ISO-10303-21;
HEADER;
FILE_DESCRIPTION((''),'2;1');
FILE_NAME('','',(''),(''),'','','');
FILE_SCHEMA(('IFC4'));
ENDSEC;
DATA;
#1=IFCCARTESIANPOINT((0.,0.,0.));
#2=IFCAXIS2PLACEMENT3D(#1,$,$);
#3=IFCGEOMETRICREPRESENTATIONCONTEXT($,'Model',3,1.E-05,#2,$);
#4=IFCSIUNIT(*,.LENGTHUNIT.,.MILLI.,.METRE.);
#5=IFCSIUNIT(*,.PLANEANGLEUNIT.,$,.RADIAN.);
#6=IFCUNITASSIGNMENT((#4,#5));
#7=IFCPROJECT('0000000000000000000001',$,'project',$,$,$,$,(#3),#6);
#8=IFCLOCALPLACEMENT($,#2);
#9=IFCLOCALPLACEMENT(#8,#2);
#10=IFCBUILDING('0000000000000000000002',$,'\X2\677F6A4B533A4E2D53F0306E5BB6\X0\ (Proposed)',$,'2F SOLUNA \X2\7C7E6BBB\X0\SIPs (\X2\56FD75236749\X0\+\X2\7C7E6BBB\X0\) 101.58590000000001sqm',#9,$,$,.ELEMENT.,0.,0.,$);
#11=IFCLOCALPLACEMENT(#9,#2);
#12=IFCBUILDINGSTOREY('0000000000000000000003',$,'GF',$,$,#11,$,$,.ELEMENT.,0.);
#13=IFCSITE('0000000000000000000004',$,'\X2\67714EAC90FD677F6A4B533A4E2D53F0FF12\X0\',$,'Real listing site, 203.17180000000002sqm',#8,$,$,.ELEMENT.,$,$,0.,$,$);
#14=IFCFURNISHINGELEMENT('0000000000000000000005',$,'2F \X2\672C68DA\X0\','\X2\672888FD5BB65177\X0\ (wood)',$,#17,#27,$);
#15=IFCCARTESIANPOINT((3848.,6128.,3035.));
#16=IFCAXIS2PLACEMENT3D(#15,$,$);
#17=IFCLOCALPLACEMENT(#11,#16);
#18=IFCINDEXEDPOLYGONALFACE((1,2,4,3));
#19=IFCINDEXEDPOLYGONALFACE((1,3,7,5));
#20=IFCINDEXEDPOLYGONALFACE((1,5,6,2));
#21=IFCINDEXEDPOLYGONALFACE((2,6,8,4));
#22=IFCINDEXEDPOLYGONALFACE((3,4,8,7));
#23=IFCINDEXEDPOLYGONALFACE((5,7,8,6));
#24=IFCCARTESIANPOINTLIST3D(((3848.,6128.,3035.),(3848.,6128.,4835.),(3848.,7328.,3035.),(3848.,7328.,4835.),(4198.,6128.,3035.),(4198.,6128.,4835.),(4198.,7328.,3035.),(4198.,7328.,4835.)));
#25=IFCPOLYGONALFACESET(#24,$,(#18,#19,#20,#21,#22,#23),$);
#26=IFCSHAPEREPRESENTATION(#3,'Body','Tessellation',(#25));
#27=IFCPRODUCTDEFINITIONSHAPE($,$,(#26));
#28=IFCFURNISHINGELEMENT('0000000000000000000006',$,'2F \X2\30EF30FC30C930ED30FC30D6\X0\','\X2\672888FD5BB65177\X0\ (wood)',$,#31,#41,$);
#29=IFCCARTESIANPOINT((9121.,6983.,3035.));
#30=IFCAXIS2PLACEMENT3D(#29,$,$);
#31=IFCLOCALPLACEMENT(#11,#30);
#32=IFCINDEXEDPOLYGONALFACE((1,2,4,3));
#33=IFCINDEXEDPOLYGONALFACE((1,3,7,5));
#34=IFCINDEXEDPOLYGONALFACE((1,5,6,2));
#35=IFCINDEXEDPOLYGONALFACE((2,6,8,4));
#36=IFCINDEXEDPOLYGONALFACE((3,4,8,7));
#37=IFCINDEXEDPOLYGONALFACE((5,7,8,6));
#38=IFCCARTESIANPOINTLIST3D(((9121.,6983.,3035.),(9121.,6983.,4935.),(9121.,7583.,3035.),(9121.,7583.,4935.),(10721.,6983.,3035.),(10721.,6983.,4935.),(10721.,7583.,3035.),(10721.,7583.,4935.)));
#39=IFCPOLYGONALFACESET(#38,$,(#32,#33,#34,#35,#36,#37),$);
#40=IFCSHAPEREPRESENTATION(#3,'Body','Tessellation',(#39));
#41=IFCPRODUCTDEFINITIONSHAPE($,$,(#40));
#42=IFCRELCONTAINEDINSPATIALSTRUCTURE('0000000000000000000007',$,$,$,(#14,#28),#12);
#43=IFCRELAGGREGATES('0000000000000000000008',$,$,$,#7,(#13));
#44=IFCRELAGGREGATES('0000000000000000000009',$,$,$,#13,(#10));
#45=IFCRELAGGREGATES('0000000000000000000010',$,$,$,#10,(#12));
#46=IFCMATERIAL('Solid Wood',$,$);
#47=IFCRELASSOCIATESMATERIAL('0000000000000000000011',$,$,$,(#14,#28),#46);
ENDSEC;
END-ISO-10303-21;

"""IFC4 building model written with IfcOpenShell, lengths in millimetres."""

from ifc_helpers import new_model, si_unit, frame, frame_2d, origin, place, context, project, spatial, rectangle, extrude, material, element, save


model = new_model("IFC4")

# Units and contexts
model_context = context("Model", 3, precision=1e-05, world=origin())
ifc_project = project(units=[si_unit("LENGTHUNIT", "METRE", prefix="MILLI"), si_unit("PLANEANGLEUNIT", "RADIAN")], contexts=[model_context])

# Site, building, storey
site_placement = place(None, origin())
site = spatial("IfcSite", under=ifc_project, at=site_placement, Name="東京都板橋区中台２", ObjectType="Real listing site, 203.17180000000002sqm", CompositionType="ELEMENT", RefElevation=0.0)
building_placement = place(site_placement, origin())
building = spatial("IfcBuilding", under=site, at=building_placement, Name="板橋区中台の家 (Proposed)", ObjectType="2F SOLUNA 籾殻SIPs (国産杉+籾殻) 101.58590000000001sqm", CompositionType="ELEMENT", ElevationOfRefHeight=0.0, ElevationOfTerrain=0.0)
storey_placement = place(building_placement, origin())
storey = spatial("IfcBuildingStorey", under=building, at=storey_placement, Name="GF", CompositionType="ELEMENT", Elevation=0.0)

# Shared definitions
ifc_material_1 = material(Name="Solid Wood")

# Furnishing elements
furnishing_1_placement = place(storey_placement, frame((3848.0, 6128.0, 3035.0)))
element("IfcFurnishingElement", 1, at=furnishing_1_placement, inside=storey, material=ifc_material_1, Name="2F 本棚", Description="木製家具 (wood)", context=model_context, shape_type="SweptSolid", body=[
    extrude(rectangle(XDim=350.0, YDim=1200.0, at=frame_2d((175.0, 600.0))), frame((3848.0, 6128.0, 3035.0)), (0.0, 0.0, 1.0), 1800.0),
])
furnishing_2_placement = place(storey_placement, frame((9121.0, 6983.0, 3035.0)))
element("IfcFurnishingElement", 2, at=furnishing_2_placement, inside=storey, material=ifc_material_1, Name="2F ワードローブ", Description="木製家具 (wood)", context=model_context, shape_type="SweptSolid", body=[
    extrude(rectangle(XDim=1600.0, YDim=600.0, at=frame_2d((800.0, 300.0))), frame((9121.0, 6983.0, 3035.0)), (0.0, 0.0, 1.0), 1900.0),
])

save(model, "model.ifc")
